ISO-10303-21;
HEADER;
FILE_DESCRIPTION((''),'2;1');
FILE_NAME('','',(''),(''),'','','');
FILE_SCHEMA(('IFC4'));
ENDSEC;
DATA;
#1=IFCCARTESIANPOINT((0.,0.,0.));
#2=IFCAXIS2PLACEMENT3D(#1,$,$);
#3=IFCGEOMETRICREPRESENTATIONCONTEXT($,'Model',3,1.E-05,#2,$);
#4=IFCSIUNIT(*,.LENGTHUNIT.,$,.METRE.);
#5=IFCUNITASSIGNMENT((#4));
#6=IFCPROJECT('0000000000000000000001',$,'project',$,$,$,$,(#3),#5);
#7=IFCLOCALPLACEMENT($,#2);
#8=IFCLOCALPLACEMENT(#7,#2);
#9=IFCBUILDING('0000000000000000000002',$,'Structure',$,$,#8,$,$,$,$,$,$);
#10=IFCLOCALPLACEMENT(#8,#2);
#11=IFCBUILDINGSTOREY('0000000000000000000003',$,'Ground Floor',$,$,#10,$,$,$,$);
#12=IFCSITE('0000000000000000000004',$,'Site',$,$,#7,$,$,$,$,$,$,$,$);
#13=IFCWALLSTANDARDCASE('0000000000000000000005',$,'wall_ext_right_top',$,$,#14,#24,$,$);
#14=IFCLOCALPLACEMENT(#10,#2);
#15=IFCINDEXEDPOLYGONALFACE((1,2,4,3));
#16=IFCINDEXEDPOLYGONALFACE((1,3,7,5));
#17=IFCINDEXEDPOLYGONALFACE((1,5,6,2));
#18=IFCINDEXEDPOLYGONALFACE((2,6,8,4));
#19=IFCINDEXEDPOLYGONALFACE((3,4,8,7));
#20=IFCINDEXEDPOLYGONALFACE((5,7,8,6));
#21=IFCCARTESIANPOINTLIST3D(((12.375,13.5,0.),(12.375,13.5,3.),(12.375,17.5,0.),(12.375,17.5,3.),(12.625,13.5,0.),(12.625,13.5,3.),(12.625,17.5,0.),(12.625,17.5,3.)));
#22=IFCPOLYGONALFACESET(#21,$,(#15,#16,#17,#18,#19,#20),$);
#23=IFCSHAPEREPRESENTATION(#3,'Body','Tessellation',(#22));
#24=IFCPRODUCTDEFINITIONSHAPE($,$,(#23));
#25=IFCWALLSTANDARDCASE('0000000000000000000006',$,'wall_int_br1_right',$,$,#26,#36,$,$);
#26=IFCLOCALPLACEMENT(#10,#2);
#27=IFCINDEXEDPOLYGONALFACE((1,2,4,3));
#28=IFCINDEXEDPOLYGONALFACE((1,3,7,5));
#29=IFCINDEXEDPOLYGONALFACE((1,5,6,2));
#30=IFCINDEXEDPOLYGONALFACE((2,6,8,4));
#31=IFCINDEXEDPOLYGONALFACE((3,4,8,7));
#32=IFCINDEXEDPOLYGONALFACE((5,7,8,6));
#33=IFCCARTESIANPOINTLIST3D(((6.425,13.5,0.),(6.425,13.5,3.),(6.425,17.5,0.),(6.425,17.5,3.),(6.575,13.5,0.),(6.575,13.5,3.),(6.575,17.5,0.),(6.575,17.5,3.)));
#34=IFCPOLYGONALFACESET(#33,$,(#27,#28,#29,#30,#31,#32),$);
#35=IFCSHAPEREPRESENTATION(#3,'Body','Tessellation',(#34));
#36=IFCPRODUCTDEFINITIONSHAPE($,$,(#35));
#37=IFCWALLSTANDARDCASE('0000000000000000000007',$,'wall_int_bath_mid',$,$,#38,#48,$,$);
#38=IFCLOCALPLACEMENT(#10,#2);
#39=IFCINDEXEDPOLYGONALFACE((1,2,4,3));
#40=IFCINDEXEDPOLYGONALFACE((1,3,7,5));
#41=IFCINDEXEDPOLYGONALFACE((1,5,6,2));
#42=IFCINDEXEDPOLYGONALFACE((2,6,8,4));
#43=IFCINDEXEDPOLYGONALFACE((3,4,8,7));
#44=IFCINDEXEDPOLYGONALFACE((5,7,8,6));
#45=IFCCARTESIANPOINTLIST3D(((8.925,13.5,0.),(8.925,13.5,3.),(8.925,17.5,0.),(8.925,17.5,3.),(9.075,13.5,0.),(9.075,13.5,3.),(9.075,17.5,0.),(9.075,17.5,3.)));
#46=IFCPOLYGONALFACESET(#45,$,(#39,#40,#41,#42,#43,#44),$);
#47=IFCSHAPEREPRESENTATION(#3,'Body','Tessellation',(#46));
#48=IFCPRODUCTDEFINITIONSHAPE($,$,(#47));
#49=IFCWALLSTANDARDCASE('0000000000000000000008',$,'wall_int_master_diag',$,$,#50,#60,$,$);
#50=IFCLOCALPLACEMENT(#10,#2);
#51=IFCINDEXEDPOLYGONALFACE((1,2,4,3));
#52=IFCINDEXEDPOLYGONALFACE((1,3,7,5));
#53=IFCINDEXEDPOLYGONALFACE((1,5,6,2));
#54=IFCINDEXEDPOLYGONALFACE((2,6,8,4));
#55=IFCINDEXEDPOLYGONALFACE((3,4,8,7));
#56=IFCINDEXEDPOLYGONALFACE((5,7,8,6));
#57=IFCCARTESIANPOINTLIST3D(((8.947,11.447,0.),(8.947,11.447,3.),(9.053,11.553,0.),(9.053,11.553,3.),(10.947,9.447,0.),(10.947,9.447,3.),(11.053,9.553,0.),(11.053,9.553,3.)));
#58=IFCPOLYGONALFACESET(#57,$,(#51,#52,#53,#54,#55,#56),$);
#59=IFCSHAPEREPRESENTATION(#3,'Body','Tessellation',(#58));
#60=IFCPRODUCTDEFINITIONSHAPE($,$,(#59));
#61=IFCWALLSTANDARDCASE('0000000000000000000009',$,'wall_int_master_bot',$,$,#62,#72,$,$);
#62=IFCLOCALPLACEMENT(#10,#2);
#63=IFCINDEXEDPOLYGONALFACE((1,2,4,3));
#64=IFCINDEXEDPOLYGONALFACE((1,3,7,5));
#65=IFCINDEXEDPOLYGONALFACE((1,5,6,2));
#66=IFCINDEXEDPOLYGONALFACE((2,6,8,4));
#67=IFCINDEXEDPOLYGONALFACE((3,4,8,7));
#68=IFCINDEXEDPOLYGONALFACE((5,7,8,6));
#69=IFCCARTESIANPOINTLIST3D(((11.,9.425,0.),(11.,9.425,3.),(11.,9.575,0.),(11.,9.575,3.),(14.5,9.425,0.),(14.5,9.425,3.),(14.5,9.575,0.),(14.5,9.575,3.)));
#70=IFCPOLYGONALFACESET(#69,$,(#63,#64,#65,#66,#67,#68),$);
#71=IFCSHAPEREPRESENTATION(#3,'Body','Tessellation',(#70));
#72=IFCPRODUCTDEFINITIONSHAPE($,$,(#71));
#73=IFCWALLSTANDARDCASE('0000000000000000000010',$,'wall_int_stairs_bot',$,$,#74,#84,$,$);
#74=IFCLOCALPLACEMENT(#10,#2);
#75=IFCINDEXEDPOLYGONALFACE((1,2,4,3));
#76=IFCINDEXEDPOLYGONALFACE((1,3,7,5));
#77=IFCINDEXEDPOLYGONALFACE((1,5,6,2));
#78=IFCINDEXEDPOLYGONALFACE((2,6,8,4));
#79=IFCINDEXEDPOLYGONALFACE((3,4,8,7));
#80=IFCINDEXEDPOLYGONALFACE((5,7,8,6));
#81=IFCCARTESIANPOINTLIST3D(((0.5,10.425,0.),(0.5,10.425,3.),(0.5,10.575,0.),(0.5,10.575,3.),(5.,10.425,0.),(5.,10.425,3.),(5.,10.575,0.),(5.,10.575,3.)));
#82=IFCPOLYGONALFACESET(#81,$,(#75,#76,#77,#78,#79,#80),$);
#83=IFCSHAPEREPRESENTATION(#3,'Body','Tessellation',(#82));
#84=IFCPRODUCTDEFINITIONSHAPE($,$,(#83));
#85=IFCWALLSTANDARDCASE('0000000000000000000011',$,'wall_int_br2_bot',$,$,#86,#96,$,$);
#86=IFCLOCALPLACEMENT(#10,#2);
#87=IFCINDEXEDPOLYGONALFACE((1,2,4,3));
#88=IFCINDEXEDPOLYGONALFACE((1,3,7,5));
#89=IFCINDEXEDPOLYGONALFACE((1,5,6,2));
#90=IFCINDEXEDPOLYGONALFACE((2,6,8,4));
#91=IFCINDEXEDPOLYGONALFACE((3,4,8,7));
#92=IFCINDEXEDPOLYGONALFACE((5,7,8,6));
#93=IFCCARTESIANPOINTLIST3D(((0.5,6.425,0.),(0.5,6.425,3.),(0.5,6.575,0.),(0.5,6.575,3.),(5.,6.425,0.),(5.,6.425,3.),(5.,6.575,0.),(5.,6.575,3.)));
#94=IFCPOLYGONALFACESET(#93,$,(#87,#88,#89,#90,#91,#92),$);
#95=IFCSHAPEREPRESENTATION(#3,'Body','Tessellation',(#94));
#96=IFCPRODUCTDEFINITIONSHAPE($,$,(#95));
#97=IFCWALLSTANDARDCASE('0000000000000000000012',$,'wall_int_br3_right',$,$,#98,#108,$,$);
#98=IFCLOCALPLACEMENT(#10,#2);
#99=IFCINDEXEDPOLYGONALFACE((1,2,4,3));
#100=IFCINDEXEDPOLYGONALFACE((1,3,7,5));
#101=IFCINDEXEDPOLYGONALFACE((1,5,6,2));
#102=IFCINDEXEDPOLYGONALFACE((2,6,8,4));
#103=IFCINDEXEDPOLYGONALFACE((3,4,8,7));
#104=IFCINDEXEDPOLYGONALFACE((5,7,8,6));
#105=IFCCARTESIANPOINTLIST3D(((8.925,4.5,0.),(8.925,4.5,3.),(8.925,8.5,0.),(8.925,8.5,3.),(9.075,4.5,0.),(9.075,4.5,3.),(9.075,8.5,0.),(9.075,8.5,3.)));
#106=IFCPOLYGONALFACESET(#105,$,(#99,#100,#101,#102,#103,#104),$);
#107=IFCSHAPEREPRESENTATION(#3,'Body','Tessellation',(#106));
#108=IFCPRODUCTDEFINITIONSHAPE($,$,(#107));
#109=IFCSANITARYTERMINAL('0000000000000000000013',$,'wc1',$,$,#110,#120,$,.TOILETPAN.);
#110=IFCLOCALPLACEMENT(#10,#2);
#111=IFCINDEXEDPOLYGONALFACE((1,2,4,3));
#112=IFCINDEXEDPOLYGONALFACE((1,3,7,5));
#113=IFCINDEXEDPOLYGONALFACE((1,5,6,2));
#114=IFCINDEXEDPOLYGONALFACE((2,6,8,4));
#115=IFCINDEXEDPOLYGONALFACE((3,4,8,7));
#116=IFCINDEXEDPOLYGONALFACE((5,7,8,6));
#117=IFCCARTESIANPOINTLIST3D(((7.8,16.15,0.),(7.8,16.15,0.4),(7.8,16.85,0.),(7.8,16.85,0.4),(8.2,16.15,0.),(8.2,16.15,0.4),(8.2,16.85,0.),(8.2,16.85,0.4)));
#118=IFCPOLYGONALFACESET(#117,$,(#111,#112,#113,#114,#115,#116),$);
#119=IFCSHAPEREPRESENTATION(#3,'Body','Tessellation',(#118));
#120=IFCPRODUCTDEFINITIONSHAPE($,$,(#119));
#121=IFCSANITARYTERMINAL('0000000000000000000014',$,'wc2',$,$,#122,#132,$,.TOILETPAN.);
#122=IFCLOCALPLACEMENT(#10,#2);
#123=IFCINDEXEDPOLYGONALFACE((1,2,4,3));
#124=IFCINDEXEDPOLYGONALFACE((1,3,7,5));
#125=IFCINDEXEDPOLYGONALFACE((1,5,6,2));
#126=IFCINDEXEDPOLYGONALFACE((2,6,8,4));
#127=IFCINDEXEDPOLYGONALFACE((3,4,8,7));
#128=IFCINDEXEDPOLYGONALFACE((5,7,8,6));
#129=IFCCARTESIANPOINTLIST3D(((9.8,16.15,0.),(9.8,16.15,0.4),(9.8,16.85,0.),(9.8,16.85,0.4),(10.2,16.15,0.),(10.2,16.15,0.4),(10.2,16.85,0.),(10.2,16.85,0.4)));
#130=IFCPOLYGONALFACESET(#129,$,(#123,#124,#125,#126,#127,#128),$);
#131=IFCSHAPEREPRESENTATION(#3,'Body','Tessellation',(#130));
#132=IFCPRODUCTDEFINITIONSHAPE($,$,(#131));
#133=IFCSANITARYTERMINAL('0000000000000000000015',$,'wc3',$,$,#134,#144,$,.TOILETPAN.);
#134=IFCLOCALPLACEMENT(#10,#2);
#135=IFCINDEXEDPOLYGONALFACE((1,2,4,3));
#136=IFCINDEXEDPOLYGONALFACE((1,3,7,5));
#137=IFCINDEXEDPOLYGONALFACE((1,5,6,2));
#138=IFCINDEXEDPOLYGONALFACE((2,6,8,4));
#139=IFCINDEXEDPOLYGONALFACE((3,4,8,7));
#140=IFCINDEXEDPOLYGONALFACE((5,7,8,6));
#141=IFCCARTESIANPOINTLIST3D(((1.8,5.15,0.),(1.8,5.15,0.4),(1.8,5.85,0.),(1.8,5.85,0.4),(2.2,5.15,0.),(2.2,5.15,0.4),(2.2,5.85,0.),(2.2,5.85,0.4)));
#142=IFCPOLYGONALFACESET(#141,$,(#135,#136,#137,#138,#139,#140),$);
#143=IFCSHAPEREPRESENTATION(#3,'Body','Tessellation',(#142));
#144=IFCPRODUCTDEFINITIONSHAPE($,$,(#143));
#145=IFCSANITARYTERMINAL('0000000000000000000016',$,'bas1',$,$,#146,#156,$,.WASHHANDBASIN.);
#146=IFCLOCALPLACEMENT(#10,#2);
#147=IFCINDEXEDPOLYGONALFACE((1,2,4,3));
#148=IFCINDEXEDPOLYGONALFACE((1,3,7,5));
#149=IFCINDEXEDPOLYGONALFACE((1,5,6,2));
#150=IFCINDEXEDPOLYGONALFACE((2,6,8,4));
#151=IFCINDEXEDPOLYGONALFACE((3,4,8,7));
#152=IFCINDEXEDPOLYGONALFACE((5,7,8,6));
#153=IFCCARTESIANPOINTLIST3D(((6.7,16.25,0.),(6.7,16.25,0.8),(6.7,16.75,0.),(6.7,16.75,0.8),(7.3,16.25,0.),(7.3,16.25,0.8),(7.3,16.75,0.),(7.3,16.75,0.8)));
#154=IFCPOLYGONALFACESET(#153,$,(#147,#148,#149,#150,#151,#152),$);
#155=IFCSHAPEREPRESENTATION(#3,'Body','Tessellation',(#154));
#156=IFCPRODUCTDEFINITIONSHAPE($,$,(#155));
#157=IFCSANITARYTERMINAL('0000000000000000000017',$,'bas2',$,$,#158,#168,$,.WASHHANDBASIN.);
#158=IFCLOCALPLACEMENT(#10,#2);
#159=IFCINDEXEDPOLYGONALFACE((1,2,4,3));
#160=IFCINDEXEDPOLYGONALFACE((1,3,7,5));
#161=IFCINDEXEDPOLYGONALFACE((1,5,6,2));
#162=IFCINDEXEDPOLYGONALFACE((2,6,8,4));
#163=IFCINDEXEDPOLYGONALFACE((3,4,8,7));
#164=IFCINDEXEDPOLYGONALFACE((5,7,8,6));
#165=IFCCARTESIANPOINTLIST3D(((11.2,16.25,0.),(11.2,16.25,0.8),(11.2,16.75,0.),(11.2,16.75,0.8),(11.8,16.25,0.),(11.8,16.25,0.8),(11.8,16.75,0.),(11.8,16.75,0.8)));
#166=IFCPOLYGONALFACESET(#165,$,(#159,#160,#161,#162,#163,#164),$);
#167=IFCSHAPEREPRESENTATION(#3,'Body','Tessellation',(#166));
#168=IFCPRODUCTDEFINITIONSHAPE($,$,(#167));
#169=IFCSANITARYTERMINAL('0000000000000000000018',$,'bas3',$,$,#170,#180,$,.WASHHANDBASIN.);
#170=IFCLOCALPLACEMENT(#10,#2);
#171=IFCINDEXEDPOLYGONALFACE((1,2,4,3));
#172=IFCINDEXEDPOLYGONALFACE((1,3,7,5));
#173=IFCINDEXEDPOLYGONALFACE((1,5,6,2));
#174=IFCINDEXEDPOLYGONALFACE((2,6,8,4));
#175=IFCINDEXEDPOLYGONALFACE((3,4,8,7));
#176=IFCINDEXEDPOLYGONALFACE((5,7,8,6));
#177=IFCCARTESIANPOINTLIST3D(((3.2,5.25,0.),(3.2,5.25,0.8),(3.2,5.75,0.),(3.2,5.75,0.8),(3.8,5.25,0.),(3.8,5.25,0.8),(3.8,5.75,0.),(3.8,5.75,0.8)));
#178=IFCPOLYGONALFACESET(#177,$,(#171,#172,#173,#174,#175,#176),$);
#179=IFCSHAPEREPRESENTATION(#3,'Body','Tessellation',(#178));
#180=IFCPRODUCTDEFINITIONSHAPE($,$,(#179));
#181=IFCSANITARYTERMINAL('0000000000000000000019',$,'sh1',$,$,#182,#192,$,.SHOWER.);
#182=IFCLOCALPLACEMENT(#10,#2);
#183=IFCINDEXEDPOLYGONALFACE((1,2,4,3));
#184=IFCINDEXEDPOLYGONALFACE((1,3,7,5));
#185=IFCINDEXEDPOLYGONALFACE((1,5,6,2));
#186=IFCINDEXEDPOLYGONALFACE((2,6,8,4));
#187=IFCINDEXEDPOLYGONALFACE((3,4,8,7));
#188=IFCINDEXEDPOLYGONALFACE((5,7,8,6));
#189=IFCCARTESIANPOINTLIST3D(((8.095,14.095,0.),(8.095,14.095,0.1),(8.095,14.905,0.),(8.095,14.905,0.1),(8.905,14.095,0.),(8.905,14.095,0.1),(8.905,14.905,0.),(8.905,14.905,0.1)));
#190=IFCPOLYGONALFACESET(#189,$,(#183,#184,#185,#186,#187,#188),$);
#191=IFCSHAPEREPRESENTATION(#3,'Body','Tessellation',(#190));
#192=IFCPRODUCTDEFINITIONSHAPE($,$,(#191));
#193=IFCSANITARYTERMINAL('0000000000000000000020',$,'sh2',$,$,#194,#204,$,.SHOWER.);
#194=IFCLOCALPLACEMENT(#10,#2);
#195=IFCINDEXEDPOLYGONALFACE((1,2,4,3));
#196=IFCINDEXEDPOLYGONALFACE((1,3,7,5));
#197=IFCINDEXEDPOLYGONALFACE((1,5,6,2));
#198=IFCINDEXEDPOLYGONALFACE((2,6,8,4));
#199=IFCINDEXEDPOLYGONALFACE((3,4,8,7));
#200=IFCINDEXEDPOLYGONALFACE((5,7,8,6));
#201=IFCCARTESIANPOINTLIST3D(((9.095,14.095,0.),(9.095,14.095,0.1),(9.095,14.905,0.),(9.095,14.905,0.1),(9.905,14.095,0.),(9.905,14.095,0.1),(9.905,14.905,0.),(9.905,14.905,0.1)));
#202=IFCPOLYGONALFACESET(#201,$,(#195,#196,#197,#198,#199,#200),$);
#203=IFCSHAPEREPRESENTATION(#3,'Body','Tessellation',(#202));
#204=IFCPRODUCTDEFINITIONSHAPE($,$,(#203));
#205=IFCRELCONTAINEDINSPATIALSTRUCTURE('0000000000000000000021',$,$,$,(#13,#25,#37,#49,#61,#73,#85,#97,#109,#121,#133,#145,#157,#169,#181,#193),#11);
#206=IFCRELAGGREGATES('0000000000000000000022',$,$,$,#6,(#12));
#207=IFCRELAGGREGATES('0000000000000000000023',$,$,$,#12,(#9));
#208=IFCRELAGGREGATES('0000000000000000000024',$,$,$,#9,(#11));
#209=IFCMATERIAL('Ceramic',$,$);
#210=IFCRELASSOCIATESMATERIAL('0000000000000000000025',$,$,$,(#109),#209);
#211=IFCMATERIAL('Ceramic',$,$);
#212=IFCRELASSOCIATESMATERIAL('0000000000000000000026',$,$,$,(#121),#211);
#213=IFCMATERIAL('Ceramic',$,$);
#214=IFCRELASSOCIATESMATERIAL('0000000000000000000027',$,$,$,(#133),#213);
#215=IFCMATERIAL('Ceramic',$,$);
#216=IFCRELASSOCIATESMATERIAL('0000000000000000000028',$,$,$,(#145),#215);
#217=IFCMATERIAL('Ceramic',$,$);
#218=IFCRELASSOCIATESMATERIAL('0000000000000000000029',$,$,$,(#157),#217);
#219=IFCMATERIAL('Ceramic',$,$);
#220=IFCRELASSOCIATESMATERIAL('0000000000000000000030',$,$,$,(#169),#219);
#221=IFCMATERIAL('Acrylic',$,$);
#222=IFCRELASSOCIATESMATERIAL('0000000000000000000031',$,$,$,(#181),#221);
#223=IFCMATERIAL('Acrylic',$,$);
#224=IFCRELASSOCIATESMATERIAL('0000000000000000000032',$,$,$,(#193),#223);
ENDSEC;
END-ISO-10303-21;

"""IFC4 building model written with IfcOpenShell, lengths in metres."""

from ifc_helpers import new_model, si_unit, frame, origin, place, context, project, spatial, polyline, outline, extrude, material, element, save


model = new_model("IFC4")

# Units and contexts
model_context = context("Model", 3, precision=1e-05, world=origin())
ifc_project = project(units=[si_unit("LENGTHUNIT", "METRE")], contexts=[model_context])

# Site, building, storey
site_placement = place(None, origin())
site = spatial("IfcSite", under=ifc_project, at=site_placement, Name="Site")
building_placement = place(site_placement, origin())
building = spatial("IfcBuilding", under=site, at=building_placement, Name="Structure")
storey_placement = place(building_placement, origin())
storey = spatial("IfcBuildingStorey", under=building, at=storey_placement, Name="Ground Floor")

# Walls
wall_1_placement = place(storey_placement, frame((12.5, 13.5, 0.0), x_axis=(0.0, 1.0, 0.0)))
element("IfcWallStandardCase", 1, at=wall_1_placement, inside=storey, Name="wall_ext_right_top", context=model_context, shape_type="SweptSolid", body=[
    extrude(outline(polyline([(0.0, -0.125), (4.0, -0.125), (4.0, 0.125), (0.0, 0.125), (0.0, -0.125)])), origin(), (0.0, 0.0, 1.0), 3.0),
])
for number, where, x_axis, name in (
    (2, (6.5, 13.5, 0.0), (0.0, 1.0, 0.0), "wall_int_br1_right"),
    (3, (9.0, 13.5, 0.0), (0.0, 1.0, 0.0), "wall_int_bath_mid"),
):
    element("IfcWallStandardCase", number, at=place(storey_placement, frame(where, x_axis=x_axis)), inside=storey, Name=name, context=model_context, shape_type="SweptSolid", body=[
        extrude(outline(polyline([(0.0, -0.075), (4.0, -0.075), (4.0, 0.075), (0.0, 0.075), (0.0, -0.075)])), origin(), (0.0, 0.0, 1.0), 3.0),
    ])
wall_2_placement = place(storey_placement, frame((9.0, 11.5, 0.0), x_axis=(0.707107, -0.707107, 0.0)))
element("IfcWallStandardCase", 4, at=wall_2_placement, inside=storey, Name="wall_int_master_diag", context=model_context, shape_type="SweptSolid", body=[
    extrude(outline(polyline([(0.0, -0.075), (2.8284, -0.075), (2.8284, 0.075), (0.0, 0.075), (0.0, -0.075)])), origin(), (0.0, 0.0, 1.0), 3.0),
])
wall_3_placement = place(storey_placement, frame((11.0, 9.5, 0.0), x_axis=(1.0, 0.0, 0.0)))
element("IfcWallStandardCase", 5, at=wall_3_placement, inside=storey, Name="wall_int_master_bot", context=model_context, shape_type="SweptSolid", body=[
    extrude(outline(polyline([(0.0, -0.075), (3.5, -0.075), (3.5, 0.075), (0.0, 0.075), (0.0, -0.075)])), origin(), (0.0, 0.0, 1.0), 3.0),
])
for number, where, x_axis, name in (
    (6, (0.5, 10.5, 0.0), (1.0, 0.0, 0.0), "wall_int_stairs_bot"),
    (7, (0.5, 6.5, 0.0), (1.0, 0.0, 0.0), "wall_int_br2_bot"),
):
    element("IfcWallStandardCase", number, at=place(storey_placement, frame(where, x_axis=x_axis)), inside=storey, Name=name, context=model_context, shape_type="SweptSolid", body=[
        extrude(outline(polyline([(0.0, -0.075), (4.5, -0.075), (4.5, 0.075), (0.0, 0.075), (0.0, -0.075)])), origin(), (0.0, 0.0, 1.0), 3.0),
    ])
wall_4_placement = place(storey_placement, frame((9.0, 4.5, 0.0), x_axis=(0.0, 1.0, 0.0)))
element("IfcWallStandardCase", 8, at=wall_4_placement, inside=storey, Name="wall_int_br3_right", context=model_context, shape_type="SweptSolid", body=[
    extrude(outline(polyline([(0.0, -0.075), (4.0, -0.075), (4.0, 0.075), (0.0, 0.075), (0.0, -0.075)])), origin(), (0.0, 0.0, 1.0), 3.0),
])

# Sanitary terminals
ifc_material_1 = material(Name="Ceramic")
sanitary_terminal_1_placement = place(storey_placement, frame((8.0, 16.5, 0.0)))
element("IfcSanitaryTerminal", 9, at=sanitary_terminal_1_placement, inside=storey, material=ifc_material_1, Name="wc1", PredefinedType="TOILETPAN", context=model_context, shape_type="SweptSolid", body=[
    extrude(outline(polyline([(-0.2, -0.35), (0.2, -0.35), (0.2, 0.35), (-0.2, 0.35), (-0.2, -0.35)])), origin(), (0.0, 0.0, 1.0), 0.4),
])
ifc_material_2 = material(Name="Ceramic")
sanitary_terminal_2_placement = place(storey_placement, frame((10.0, 16.5, 0.0)))
element("IfcSanitaryTerminal", 10, at=sanitary_terminal_2_placement, inside=storey, material=ifc_material_2, Name="wc2", PredefinedType="TOILETPAN", context=model_context, shape_type="SweptSolid", body=[
    extrude(outline(polyline([(-0.2, -0.35), (0.2, -0.35), (0.2, 0.35), (-0.2, 0.35), (-0.2, -0.35)])), origin(), (0.0, 0.0, 1.0), 0.4),
])
ifc_material_3 = material(Name="Ceramic")
sanitary_terminal_3_placement = place(storey_placement, frame((2.0, 5.5, 0.0)))
element("IfcSanitaryTerminal", 11, at=sanitary_terminal_3_placement, inside=storey, material=ifc_material_3, Name="wc3", PredefinedType="TOILETPAN", context=model_context, shape_type="SweptSolid", body=[
    extrude(outline(polyline([(-0.2, -0.35), (0.2, -0.35), (0.2, 0.35), (-0.2, 0.35), (-0.2, -0.35)])), origin(), (0.0, 0.0, 1.0), 0.4),
])
ifc_material_4 = material(Name="Ceramic")
sanitary_terminal_4_placement = place(storey_placement, frame((7.0, 16.5, 0.0)))
element("IfcSanitaryTerminal", 12, at=sanitary_terminal_4_placement, inside=storey, material=ifc_material_4, Name="bas1", PredefinedType="WASHHANDBASIN", context=model_context, shape_type="SweptSolid", body=[
    extrude(outline(polyline([(-0.3, -0.25), (0.3, -0.25), (0.3, 0.25), (-0.3, 0.25), (-0.3, -0.25)])), origin(), (0.0, 0.0, 1.0), 0.8),
])
ifc_material_5 = material(Name="Ceramic")
sanitary_terminal_5_placement = place(storey_placement, frame((11.5, 16.5, 0.0)))
element("IfcSanitaryTerminal", 13, at=sanitary_terminal_5_placement, inside=storey, material=ifc_material_5, Name="bas2", PredefinedType="WASHHANDBASIN", context=model_context, shape_type="SweptSolid", body=[
    extrude(outline(polyline([(-0.3, -0.25), (0.3, -0.25), (0.3, 0.25), (-0.3, 0.25), (-0.3, -0.25)])), origin(), (0.0, 0.0, 1.0), 0.8),
])
ifc_material_6 = material(Name="Ceramic")
sanitary_terminal_6_placement = place(storey_placement, frame((3.5, 5.5, 0.0)))
element("IfcSanitaryTerminal", 14, at=sanitary_terminal_6_placement, inside=storey, material=ifc_material_6, Name="bas3", PredefinedType="WASHHANDBASIN", context=model_context, shape_type="SweptSolid", body=[
    extrude(outline(polyline([(-0.3, -0.25), (0.3, -0.25), (0.3, 0.25), (-0.3, 0.25), (-0.3, -0.25)])), origin(), (0.0, 0.0, 1.0), 0.8),
])
ifc_material_7 = material(Name="Acrylic")
sanitary_terminal_7_placement = place(storey_placement, frame((8.5, 14.5, 0.0)))
element("IfcSanitaryTerminal", 15, at=sanitary_terminal_7_placement, inside=storey, material=ifc_material_7, Name="sh1", PredefinedType="SHOWER", context=model_context, shape_type="SweptSolid", body=[
    extrude(outline(polyline([(-0.405, -0.405), (0.405, -0.405), (0.405, 0.405), (-0.405, 0.405), (-0.405, -0.405)])), origin(), (0.0, 0.0, 1.0), 0.1),
])
ifc_material_8 = material(Name="Acrylic")
sanitary_terminal_8_placement = place(storey_placement, frame((9.5, 14.5, 0.0)))
element("IfcSanitaryTerminal", 16, at=sanitary_terminal_8_placement, inside=storey, material=ifc_material_8, Name="sh2", PredefinedType="SHOWER", context=model_context, shape_type="SweptSolid", body=[
    extrude(outline(polyline([(-0.405, -0.405), (0.405, -0.405), (0.405, 0.405), (-0.405, 0.405), (-0.405, -0.405)])), origin(), (0.0, 0.0, 1.0), 0.1),
])

save(model, "model.ifc")
